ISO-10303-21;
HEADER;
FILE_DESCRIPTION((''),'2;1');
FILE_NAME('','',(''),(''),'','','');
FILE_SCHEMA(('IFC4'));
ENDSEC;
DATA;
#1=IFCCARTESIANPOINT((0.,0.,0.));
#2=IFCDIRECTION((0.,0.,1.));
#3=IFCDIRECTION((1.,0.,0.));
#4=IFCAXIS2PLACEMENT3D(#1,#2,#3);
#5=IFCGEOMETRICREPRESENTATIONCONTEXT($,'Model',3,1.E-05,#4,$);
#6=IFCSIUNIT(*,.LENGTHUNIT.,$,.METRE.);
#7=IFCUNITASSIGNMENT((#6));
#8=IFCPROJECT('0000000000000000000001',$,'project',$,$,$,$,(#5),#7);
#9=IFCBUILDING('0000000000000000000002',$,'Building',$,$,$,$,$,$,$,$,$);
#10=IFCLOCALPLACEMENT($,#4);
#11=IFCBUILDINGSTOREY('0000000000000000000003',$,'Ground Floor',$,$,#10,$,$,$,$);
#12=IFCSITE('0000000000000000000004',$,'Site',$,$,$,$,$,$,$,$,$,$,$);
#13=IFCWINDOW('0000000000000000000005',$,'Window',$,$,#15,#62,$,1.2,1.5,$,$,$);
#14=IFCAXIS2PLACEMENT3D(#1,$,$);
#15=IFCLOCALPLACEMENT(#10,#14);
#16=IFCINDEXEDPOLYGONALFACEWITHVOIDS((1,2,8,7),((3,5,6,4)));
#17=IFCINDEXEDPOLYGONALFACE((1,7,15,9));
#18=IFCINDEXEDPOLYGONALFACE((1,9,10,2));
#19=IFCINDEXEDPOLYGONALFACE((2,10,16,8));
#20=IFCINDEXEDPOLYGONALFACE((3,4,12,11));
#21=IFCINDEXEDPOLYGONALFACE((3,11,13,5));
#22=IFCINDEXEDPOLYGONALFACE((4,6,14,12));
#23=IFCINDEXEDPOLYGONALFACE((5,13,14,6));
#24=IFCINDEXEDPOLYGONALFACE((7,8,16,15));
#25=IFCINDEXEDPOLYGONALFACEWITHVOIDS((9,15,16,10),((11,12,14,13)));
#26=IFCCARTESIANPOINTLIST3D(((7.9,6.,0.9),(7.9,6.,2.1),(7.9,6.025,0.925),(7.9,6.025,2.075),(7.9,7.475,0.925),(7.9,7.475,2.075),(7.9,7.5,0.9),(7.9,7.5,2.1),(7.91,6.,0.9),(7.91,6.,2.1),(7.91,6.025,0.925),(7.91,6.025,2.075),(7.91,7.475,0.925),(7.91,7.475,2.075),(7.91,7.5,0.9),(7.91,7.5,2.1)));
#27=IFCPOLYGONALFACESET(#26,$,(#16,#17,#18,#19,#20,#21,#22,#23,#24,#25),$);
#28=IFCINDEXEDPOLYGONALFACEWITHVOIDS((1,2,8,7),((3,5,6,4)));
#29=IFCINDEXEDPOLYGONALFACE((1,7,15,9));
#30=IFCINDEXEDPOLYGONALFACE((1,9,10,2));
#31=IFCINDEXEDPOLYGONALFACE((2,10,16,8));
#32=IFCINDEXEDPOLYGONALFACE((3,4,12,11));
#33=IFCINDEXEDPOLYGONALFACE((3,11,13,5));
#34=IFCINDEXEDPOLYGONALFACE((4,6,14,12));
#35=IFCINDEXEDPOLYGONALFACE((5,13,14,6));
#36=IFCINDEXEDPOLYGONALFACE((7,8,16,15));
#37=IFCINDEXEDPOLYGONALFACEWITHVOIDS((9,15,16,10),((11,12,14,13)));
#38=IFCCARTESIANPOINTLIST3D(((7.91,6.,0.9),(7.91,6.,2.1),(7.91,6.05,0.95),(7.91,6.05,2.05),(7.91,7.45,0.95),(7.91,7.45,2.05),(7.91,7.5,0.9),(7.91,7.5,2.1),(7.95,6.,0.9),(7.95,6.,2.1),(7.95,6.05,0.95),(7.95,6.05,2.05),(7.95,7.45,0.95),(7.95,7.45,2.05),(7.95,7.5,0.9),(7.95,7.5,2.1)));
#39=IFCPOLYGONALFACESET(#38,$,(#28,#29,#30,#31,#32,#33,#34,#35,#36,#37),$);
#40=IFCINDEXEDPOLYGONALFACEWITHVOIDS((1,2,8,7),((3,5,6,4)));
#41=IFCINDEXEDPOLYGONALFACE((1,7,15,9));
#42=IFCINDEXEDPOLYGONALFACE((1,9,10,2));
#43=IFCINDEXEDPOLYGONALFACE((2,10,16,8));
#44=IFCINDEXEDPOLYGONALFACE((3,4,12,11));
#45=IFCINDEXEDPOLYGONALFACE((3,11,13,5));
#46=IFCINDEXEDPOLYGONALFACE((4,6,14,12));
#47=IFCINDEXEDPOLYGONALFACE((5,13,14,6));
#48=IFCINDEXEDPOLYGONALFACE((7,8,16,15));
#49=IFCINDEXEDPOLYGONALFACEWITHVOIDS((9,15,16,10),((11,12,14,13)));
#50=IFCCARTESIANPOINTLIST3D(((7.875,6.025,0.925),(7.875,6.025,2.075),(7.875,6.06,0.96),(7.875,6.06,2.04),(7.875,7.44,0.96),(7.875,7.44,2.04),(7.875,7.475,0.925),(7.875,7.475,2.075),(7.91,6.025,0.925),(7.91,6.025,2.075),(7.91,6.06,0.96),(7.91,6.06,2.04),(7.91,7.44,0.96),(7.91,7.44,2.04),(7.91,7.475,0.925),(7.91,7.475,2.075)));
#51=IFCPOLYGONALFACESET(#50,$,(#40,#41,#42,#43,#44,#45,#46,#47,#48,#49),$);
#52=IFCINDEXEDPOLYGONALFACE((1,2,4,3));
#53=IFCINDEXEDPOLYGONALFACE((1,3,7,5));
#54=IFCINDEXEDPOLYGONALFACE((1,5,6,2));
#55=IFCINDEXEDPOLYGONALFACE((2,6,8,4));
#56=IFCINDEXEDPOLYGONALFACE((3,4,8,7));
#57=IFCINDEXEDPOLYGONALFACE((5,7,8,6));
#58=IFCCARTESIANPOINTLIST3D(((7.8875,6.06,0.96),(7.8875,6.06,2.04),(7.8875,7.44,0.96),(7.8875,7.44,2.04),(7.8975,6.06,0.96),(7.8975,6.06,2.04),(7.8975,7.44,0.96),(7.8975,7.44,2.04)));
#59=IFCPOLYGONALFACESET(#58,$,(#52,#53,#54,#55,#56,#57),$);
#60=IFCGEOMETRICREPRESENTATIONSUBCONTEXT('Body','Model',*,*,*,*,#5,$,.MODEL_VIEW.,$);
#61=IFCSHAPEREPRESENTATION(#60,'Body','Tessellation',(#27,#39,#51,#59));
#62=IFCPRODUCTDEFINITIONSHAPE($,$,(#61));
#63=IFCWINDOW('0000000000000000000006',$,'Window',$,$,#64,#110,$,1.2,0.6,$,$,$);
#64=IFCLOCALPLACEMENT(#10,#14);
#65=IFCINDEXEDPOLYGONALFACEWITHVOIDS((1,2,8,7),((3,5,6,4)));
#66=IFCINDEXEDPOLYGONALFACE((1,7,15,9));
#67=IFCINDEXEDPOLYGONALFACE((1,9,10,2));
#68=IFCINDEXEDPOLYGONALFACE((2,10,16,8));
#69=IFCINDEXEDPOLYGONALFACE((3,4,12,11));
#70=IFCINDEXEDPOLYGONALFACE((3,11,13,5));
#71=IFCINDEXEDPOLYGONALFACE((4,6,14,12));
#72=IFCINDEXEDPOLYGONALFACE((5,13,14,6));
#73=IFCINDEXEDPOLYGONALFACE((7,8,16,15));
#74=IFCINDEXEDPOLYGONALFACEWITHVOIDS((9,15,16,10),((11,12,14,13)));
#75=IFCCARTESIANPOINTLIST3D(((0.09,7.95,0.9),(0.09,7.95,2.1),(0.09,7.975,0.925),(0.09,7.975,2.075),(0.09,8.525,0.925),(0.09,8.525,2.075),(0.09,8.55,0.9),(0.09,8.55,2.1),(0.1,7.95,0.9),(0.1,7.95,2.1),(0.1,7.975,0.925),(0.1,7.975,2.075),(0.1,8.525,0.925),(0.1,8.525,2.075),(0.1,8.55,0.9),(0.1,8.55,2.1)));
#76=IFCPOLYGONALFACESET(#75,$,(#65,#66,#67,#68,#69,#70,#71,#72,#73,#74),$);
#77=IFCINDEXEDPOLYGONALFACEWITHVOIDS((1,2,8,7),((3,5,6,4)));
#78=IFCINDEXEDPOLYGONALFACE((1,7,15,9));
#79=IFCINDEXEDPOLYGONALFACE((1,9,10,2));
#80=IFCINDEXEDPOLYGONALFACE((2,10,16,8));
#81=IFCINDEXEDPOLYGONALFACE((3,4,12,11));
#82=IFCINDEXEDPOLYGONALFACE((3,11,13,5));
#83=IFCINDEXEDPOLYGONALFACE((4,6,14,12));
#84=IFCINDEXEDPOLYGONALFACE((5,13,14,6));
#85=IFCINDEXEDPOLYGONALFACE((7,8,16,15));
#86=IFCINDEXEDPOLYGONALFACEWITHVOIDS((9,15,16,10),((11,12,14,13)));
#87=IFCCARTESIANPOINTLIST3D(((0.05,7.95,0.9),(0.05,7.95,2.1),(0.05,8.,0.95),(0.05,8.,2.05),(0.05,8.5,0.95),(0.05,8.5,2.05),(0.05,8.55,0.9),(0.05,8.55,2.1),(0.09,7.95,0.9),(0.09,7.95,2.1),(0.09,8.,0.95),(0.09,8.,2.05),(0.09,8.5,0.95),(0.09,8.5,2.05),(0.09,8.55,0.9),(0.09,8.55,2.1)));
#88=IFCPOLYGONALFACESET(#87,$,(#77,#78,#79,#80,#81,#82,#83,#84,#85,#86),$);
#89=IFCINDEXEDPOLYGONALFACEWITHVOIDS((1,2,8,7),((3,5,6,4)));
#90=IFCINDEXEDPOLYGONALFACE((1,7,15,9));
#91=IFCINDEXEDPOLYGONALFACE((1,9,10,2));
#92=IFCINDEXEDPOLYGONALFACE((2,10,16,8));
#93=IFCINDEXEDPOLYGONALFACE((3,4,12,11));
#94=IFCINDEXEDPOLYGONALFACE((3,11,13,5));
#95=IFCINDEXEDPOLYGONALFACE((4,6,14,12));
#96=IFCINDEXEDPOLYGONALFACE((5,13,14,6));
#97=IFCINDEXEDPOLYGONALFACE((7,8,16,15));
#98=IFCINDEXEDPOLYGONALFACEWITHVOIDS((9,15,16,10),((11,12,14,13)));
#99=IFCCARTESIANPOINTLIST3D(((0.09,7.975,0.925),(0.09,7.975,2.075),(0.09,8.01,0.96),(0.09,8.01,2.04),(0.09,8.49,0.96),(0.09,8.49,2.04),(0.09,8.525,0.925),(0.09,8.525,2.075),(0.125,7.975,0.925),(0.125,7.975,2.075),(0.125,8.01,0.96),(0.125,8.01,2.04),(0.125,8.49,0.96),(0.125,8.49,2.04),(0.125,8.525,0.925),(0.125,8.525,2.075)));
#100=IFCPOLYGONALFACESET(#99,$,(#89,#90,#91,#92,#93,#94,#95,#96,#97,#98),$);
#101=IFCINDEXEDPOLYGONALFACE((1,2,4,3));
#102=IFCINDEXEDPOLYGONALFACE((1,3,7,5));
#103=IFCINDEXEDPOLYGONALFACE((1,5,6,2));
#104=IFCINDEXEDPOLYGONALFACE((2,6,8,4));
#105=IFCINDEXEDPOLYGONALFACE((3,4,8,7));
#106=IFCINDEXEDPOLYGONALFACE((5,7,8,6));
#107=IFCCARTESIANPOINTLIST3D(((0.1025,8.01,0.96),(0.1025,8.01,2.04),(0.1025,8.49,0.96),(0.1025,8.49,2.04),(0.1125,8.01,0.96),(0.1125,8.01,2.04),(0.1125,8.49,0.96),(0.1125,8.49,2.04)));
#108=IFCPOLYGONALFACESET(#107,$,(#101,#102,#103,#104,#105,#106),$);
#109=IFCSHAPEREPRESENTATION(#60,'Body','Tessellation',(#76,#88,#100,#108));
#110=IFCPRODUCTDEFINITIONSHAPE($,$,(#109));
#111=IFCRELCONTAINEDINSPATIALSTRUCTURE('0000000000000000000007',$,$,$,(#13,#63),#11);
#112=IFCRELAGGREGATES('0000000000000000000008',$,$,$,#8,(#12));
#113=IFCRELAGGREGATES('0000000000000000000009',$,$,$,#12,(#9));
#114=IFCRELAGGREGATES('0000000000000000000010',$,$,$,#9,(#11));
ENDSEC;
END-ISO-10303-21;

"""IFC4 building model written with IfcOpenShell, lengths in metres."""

from ifc_helpers import new_model, si_unit, frame, origin_with_axes, place, context, subcontext, project, spatial, line, indexed_curve, outline, extrude, element, save


model = new_model("IFC4")

# Units and contexts
model_context = context("Model", 3, precision=1e-05, world=origin_with_axes())
body_context = subcontext(model_context, "Body", "Model", "MODEL_VIEW")
ifc_project = project(units=[si_unit("LENGTHUNIT", "METRE")], contexts=[model_context])

# Site, building, storey
site = spatial("IfcSite", under=ifc_project, Name="Site")
building = spatial("IfcBuilding", under=site, Name="Building")
storey_placement = place(None, origin_with_axes())
storey = spatial("IfcBuildingStorey", under=building, at=storey_placement, Name="Ground Floor")

# Windows
for number, where, z_axis, x_axis, name in (
    (1, (8.0, 6.0, 0.9), (0.0, 0.0, 1.0), (0.0, 1.0, 0.0), "Window"),
):
    element("IfcWindow", number, at=place(storey_placement, frame(where, z_axis=z_axis, x_axis=x_axis)), inside=storey, Name=name, OverallHeight=1.2, OverallWidth=1.5, context=body_context, shape_type="SweptSolid", body=[
        extrude(outline(indexed_curve([(0.0, 0.0), (1.5, 0.0), (1.5, 1.2), (0.0, 1.2)], segments=[line(1, 2, 3, 4, 1)]), holes=[indexed_curve([(0.025, 0.025), (1.475, 0.025), (1.475, 1.175), (0.025, 1.175)], segments=[line(1, 2, 3, 4, 1)])]), frame((0.0, 0.09, 0.0), z_axis=(0.0, -1.0, 0.0), x_axis=(1.0, 0.0, 0.0)), (0.0, 0.0, -1.0), 0.01),
        extrude(outline(indexed_curve([(0.0, 0.0), (1.5, 0.0), (1.5, 1.2), (0.0, 1.2)], segments=[line(1, 2, 3, 4, 1)]), holes=[indexed_curve([(0.05, 0.05), (1.45, 0.05), (1.45, 1.15), (0.05, 1.15)], segments=[line(1, 2, 3, 4, 1)])]), frame((0.0, 0.05, 0.0), z_axis=(0.0, -1.0, 0.0), x_axis=(1.0, 0.0, 0.0)), (0.0, 0.0, -1.0), 0.04),
        extrude(outline(indexed_curve([(0.0, 0.0), (1.45, 0.0), (1.45, 1.15), (0.0, 1.15)], segments=[line(1, 2, 3, 4, 1)]), holes=[indexed_curve([(0.035, 0.035), (1.415, 0.035), (1.415, 1.115), (0.035, 1.115)], segments=[line(1, 2, 3, 4, 1)])]), frame((0.025, 0.09, 0.025), z_axis=(0.0, -1.0, 0.0), x_axis=(1.0, 0.0, 0.0)), (0.0, 0.0, -1.0), 0.035),
        extrude(outline(indexed_curve([(0.035, 0.035), (1.415, 0.035), (1.415, 1.115), (0.035, 1.115)], segments=[line(1, 2, 3, 4, 1)])), frame((0.025, 0.1025, 0.025), z_axis=(0.0, -1.0, 0.0), x_axis=(1.0, 0.0, 0.0)), (0.0, 0.0, -1.0), 0.01),
    ])
window_1_placement = place(storey_placement, frame((0.0, 8.55, 0.9), z_axis=(0.0, 0.0, 1.0), x_axis=(0.0, -1.0, 0.0)))
element("IfcWindow", 2, at=window_1_placement, inside=storey, Name="Window", OverallHeight=1.2, OverallWidth=0.6, context=body_context, shape_type="SweptSolid", body=[
    extrude(outline(indexed_curve([(0.0, 0.0), (0.6, 0.0), (0.6, 1.2), (0.0, 1.2)], segments=[line(1, 2, 3, 4, 1)]), holes=[indexed_curve([(0.025, 0.025), (0.575, 0.025), (0.575, 1.175), (0.025, 1.175)], segments=[line(1, 2, 3, 4, 1)])]), frame((0.0, 0.09, 0.0), z_axis=(0.0, -1.0, 0.0), x_axis=(1.0, 0.0, 0.0)), (0.0, 0.0, -1.0), 0.01),
    extrude(outline(indexed_curve([(0.0, 0.0), (0.6, 0.0), (0.6, 1.2), (0.0, 1.2)], segments=[line(1, 2, 3, 4, 1)]), holes=[indexed_curve([(0.05, 0.05), (0.55, 0.05), (0.55, 1.15), (0.05, 1.15)], segments=[line(1, 2, 3, 4, 1)])]), frame((0.0, 0.05, 0.0), z_axis=(0.0, -1.0, 0.0), x_axis=(1.0, 0.0, 0.0)), (0.0, 0.0, -1.0), 0.04),
    extrude(outline(indexed_curve([(0.0, 0.0), (0.55, 0.0), (0.55, 1.15), (0.0, 1.15)], segments=[line(1, 2, 3, 4, 1)]), holes=[indexed_curve([(0.035, 0.035), (0.515, 0.035), (0.515, 1.115), (0.035, 1.115)], segments=[line(1, 2, 3, 4, 1)])]), frame((0.025, 0.09, 0.025), z_axis=(0.0, -1.0, 0.0), x_axis=(1.0, 0.0, 0.0)), (0.0, 0.0, -1.0), 0.035),
    extrude(outline(indexed_curve([(0.035, 0.035), (0.515, 0.035), (0.515, 1.115), (0.035, 1.115)], segments=[line(1, 2, 3, 4, 1)])), frame((0.025, 0.1025, 0.025), z_axis=(0.0, -1.0, 0.0), x_axis=(1.0, 0.0, 0.0)), (0.0, 0.0, -1.0), 0.01),
])

save(model, "model.ifc")
